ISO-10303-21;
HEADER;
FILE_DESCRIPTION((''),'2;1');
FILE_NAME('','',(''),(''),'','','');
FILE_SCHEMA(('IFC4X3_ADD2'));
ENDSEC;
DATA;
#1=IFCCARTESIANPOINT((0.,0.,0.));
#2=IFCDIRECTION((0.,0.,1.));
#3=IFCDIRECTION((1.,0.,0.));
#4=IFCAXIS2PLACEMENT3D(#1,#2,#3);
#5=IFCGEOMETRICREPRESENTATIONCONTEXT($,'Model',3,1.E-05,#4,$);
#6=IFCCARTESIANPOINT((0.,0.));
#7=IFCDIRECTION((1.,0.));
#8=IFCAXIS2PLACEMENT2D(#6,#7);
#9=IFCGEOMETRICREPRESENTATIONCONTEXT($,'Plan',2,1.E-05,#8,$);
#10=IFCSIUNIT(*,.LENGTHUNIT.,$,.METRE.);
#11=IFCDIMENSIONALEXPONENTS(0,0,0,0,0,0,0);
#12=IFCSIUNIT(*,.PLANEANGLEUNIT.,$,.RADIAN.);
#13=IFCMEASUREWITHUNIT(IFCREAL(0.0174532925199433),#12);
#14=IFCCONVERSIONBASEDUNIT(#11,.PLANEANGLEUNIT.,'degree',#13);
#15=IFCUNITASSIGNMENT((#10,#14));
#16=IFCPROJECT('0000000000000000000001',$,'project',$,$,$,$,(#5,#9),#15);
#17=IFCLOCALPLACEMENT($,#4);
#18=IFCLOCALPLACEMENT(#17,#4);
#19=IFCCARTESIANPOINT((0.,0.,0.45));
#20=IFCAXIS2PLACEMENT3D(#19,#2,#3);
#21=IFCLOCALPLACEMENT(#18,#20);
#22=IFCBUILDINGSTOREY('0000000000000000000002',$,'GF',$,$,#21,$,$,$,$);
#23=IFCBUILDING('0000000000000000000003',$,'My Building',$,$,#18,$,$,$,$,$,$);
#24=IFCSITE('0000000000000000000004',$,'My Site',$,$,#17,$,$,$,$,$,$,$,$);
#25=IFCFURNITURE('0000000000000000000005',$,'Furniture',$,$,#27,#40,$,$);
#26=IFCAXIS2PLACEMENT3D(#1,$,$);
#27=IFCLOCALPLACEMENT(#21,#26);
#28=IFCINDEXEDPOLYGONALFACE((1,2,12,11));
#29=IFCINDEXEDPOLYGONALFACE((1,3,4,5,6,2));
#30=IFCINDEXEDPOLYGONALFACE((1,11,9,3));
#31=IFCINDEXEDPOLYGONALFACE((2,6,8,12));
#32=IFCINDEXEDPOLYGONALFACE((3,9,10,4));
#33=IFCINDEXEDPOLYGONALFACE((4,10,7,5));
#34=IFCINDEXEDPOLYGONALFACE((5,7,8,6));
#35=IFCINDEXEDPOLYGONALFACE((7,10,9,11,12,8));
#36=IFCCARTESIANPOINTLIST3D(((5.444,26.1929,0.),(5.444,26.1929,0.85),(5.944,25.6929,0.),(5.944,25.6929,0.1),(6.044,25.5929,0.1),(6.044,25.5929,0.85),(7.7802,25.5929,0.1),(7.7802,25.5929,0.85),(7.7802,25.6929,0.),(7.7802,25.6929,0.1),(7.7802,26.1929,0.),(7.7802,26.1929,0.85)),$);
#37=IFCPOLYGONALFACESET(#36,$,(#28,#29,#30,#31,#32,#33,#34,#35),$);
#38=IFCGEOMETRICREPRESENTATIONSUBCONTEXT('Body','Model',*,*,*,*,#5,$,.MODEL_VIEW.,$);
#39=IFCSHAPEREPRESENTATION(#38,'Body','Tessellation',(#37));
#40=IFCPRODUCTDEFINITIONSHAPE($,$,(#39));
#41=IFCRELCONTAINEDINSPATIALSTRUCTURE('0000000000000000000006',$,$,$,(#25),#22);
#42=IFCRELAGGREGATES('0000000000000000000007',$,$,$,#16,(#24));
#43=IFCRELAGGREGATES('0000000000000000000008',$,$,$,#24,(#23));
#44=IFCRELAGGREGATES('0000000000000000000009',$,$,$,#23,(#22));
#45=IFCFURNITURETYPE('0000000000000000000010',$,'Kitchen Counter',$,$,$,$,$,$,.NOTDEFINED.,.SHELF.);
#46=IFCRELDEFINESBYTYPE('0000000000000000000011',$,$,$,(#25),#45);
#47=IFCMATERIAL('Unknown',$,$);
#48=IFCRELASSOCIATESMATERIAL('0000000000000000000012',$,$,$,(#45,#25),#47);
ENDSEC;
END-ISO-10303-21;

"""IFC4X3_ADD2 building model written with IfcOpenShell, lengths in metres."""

from ifc_helpers import new_model, entity, si_unit, converted_unit, frame, origin_with_axes, origin_2d_with_axis, place, context, subcontext, project, spatial, indexed_curve, outline, extrude, clip, halfspace, material, material_profile, profile_set, profile_usage, type_object, element, save


model = new_model("IFC4X3_ADD2")

# Units and contexts
model_context = context("Model", 3, precision=1e-05, world=origin_with_axes())
plan_context = context("Plan", 2, precision=1e-05, world=origin_2d_with_axis())
body_context_1 = subcontext(model_context, "Body", "Model", "MODEL_VIEW")
ifc_project = project(units=[si_unit("LENGTHUNIT", "METRE"), converted_unit("PLANEANGLEUNIT", "degree", entity("IfcReal", 0.0174532925199433), si_unit("PLANEANGLEUNIT", "RADIAN"), dimensions=[0, 0, 0, 0, 0, 0, 0])], contexts=[model_context, plan_context])

# Site, building, storey
site_placement = place(None, origin_with_axes())
site = spatial("IfcSite", under=ifc_project, at=site_placement, Name="My Site")
building_placement = place(site_placement, origin_with_axes())
building = spatial("IfcBuilding", under=site, at=building_placement, Name="My Building")
storey_placement = place(building_placement, frame((0.0, 0.0, 0.45), z_axis=(0.0, 0.0, 1.0), x_axis=(1.0, 0.0, 0.0)))
storey = spatial("IfcBuildingStorey", under=building, at=storey_placement, Name="GF")

# Furniture
ifc_material_1 = material(Name="Unknown")
ifc_material_profile_1 = material_profile(ifc_material_1, outline(indexed_curve([(0.5, 0.1), (0.6, 0.1), (0.6, 0.85), (0.0, 0.85), (0.0, 0.0), (0.5, 0.0), (0.5, 0.1)])))
ifc_profile_set_1 = profile_set([ifc_material_profile_1])
furniture_type_1 = type_object("IfcFurnitureType", Name="Kitchen Counter", AssemblyPlace="NOTDEFINED", PredefinedType="SHELF", material=ifc_profile_set_1)
ifc_profile_usage_1 = profile_usage(ifc_profile_set_1, cardinal=5)
furniture_1_placement = place(storey_placement, frame((7.7802, 26.1929, 0.0), z_axis=(-1.0, 0.0, 0.0), x_axis=(0.0, -1.0, 0.0)))
element("IfcFurniture", 1, at=furniture_1_placement, inside=storey, type_object=furniture_type_1, material=ifc_profile_usage_1, Name="Furniture", context=body_context_1, shape_type="Clipping", body=[
    clip(extrude(outline(indexed_curve([(0.5, 0.1), (0.6, 0.1), (0.6, 0.85), (0.0, 0.85), (0.0, 0.0), (0.5, 0.0), (0.5, 0.1)])), frame((0.0, 0.0, 0.0), z_axis=(0.0, 0.0, 1.0), x_axis=(1.0, 0.0, 0.0)), (0.0, 0.0, 1.0), 2.3362), halfspace(frame((0.0, -0.45, 2.3362), z_axis=(0.707107, 0.0, 0.707107), x_axis=(0.0, -1.0, 0.0)), False)),
])

save(model, "model.ifc")
